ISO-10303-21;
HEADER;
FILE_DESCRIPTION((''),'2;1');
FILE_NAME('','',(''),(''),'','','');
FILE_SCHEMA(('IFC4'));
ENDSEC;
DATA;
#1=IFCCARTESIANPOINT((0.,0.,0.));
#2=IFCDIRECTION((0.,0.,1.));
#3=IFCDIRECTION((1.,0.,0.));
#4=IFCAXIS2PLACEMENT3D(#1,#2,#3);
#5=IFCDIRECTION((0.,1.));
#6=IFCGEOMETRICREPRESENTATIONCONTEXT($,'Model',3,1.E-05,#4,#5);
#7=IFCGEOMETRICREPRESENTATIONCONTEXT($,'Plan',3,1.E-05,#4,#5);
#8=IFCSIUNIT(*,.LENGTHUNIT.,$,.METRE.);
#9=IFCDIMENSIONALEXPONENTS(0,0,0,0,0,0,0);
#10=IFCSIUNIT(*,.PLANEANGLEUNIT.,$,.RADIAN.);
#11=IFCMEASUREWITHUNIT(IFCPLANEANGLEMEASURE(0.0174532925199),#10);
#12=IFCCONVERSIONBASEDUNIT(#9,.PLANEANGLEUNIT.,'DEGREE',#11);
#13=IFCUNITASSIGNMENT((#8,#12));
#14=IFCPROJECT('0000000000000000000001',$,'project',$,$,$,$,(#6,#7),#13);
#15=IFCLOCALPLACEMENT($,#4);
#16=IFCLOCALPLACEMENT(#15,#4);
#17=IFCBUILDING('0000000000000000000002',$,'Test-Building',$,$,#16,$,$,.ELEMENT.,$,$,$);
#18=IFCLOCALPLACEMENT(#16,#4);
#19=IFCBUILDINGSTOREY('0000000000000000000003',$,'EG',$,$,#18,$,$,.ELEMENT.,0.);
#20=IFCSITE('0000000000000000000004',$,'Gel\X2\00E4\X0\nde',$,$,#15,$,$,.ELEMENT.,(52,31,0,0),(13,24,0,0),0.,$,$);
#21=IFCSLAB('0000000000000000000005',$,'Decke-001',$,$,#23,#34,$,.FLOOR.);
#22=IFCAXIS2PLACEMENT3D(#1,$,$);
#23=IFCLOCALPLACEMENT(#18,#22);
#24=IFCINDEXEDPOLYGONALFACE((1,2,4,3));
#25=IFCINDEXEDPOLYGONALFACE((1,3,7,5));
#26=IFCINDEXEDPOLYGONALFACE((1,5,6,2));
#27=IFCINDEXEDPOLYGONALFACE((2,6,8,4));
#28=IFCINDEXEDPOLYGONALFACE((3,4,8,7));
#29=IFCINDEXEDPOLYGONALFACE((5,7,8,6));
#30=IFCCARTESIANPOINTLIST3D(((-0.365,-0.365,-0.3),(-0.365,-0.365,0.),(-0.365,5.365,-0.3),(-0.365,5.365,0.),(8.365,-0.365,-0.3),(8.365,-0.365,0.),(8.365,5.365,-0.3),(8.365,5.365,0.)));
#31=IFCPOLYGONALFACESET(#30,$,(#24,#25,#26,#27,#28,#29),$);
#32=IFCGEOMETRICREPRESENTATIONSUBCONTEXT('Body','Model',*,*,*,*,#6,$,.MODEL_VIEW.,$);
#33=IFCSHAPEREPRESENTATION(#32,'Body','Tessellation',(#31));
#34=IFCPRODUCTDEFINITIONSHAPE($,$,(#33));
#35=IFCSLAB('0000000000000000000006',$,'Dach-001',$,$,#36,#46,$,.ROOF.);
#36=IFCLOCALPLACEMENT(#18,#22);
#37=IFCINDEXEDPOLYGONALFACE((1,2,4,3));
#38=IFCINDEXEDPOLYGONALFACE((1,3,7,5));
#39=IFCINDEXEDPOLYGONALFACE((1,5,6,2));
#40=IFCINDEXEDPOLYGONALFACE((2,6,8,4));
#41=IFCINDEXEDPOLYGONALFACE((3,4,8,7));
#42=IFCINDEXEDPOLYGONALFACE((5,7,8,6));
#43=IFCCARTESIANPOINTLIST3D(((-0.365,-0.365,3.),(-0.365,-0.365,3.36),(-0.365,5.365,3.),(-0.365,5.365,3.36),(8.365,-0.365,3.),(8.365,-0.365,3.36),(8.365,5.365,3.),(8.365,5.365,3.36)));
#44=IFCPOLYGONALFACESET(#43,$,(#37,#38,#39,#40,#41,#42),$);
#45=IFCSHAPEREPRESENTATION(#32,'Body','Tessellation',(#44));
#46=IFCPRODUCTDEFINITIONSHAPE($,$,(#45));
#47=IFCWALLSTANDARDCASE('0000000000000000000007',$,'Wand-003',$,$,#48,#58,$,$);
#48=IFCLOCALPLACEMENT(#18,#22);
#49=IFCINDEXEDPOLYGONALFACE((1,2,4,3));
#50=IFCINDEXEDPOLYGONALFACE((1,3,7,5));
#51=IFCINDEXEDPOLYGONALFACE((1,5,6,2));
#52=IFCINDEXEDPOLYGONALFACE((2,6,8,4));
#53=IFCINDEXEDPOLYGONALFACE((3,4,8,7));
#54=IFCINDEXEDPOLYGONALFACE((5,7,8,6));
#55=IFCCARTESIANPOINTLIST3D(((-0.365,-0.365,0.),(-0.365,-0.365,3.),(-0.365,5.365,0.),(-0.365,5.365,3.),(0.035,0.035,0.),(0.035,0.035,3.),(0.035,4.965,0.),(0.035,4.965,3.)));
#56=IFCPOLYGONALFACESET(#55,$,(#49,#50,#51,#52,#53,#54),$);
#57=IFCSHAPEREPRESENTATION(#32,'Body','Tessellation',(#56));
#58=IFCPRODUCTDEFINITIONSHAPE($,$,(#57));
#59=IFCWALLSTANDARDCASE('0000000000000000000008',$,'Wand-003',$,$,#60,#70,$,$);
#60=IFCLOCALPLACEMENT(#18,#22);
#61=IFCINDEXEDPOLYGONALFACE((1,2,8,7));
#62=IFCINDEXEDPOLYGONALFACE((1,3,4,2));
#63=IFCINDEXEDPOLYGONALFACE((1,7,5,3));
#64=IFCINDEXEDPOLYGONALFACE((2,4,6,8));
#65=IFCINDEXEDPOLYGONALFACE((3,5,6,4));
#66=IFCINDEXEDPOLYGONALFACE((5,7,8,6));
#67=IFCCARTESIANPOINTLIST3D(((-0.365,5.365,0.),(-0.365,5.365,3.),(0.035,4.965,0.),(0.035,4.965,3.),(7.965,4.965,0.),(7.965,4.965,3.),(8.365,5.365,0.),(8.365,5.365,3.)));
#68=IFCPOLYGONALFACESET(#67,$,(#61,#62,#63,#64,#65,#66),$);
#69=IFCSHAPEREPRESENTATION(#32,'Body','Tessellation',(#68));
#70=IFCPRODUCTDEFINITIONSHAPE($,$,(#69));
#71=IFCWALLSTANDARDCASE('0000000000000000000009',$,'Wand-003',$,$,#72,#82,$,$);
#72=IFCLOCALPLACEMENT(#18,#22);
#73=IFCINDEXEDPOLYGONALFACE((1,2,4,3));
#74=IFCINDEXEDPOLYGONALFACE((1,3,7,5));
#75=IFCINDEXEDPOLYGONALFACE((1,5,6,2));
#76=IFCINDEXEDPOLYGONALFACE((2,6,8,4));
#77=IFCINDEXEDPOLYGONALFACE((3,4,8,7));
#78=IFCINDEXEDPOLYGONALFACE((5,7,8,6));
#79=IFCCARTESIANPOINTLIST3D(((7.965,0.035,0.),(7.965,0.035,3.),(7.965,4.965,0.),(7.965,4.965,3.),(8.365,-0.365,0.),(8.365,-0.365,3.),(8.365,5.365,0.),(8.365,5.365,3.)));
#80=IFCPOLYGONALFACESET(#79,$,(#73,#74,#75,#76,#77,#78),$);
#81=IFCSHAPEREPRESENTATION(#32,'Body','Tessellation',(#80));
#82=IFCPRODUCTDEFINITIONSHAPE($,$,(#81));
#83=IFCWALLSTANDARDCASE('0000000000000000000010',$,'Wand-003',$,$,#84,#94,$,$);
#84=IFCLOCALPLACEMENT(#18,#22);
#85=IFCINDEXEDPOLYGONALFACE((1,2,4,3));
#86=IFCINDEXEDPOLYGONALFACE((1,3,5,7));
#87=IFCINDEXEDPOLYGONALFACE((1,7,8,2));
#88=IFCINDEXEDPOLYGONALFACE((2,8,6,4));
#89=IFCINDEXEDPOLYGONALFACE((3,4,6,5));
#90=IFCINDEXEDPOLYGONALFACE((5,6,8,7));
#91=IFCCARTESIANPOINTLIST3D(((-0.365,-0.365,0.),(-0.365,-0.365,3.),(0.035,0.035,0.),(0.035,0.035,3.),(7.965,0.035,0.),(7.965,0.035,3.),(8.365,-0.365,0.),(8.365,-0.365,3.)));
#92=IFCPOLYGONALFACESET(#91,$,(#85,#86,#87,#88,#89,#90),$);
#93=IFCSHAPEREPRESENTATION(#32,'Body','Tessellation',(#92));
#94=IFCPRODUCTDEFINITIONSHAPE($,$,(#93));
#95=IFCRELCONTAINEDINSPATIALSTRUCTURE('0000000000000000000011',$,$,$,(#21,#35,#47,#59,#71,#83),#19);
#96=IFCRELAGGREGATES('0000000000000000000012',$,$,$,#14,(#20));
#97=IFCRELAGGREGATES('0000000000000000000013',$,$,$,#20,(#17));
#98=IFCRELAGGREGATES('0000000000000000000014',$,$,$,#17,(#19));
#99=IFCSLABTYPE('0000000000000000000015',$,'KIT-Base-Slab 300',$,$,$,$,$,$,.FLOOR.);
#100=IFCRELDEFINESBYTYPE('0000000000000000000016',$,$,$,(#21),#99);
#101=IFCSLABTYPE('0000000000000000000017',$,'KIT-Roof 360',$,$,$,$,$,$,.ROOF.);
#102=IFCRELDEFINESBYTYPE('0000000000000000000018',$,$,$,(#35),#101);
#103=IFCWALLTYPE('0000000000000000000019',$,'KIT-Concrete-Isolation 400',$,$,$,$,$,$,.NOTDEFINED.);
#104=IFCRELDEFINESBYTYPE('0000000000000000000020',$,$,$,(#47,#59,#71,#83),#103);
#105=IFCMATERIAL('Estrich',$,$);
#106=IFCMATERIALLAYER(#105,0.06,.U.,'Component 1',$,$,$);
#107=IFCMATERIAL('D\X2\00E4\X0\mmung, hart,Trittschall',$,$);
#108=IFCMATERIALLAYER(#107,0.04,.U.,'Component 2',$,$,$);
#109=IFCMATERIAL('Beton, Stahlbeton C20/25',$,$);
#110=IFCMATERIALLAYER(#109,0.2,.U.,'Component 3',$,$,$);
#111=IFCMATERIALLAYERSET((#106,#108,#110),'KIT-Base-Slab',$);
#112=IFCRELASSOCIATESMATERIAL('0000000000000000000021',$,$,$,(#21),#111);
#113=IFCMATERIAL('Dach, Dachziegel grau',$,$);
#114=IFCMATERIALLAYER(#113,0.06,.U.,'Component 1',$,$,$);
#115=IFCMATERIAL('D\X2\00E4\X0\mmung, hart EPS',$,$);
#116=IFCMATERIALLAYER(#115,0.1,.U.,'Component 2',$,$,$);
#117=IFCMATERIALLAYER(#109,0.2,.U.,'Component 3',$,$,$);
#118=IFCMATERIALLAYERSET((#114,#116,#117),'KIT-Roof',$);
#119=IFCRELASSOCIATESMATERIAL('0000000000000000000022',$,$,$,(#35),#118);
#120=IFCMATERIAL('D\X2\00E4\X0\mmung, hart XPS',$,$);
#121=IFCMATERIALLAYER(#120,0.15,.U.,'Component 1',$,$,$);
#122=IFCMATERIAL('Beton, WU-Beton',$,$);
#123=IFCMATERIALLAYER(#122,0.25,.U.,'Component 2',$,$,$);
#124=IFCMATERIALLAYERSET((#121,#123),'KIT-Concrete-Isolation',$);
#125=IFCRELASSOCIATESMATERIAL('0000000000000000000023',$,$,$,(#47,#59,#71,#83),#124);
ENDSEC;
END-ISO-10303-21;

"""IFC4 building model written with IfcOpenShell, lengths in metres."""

from ifc_helpers import new_model, entity, si_unit, converted_unit, direction, frame, origin_with_axes, place, context, subcontext, project, spatial, polyline, outline, extrude, material, layer, layer_set, layer_usage, type_object, element, save


model = new_model("IFC4")

# Units and contexts
model_context = context("Model", 3, precision=1e-05, world=origin_with_axes(), true_north=direction((0.0, 1.0)))
plan_context = context("Plan", 3, precision=1e-05, world=origin_with_axes(), true_north=direction((0.0, 1.0)))
body_context = subcontext(model_context, "Body", "Model", "MODEL_VIEW")
ifc_project = project(units=[si_unit("LENGTHUNIT", "METRE"), converted_unit("PLANEANGLEUNIT", "DEGREE", entity("IfcPlaneAngleMeasure", 0.0174532925199), si_unit("PLANEANGLEUNIT", "RADIAN"), dimensions=[0, 0, 0, 0, 0, 0, 0])], contexts=[model_context, plan_context])

# Site, building, storey
site_placement = place(None, origin_with_axes())
site = spatial("IfcSite", under=ifc_project, at=site_placement, Name="Gelände", CompositionType="ELEMENT", RefLatitude=(52, 31, 0, 0), RefLongitude=(13, 24, 0, 0), RefElevation=0.0)
building_placement = place(site_placement, origin_with_axes())
building = spatial("IfcBuilding", under=site, at=building_placement, Name="Test-Building", CompositionType="ELEMENT")
storey_placement = place(building_placement, origin_with_axes())
storey = spatial("IfcBuildingStorey", under=building, at=storey_placement, Name="EG", CompositionType="ELEMENT", Elevation=0.0)

# Slabs
ifc_material_1 = material(Name="Estrich")
ifc_layer_1 = layer(ifc_material_1, 0.06, ventilated="UNKNOWN", Name="Component 1")
ifc_material_2 = material(Name="Dämmung, hart,Trittschall")
ifc_layer_2 = layer(ifc_material_2, 0.04, ventilated="UNKNOWN", Name="Component 2")
ifc_material_3 = material(Name="Beton, Stahlbeton C20/25")
ifc_layer_3 = layer(ifc_material_3, 0.2, ventilated="UNKNOWN", Name="Component 3")
ifc_layer_set_1 = layer_set([ifc_layer_1, ifc_layer_2, ifc_layer_3], Name="KIT-Base-Slab")
ifc_layer_usage_1 = layer_usage(ifc_layer_set_1, "AXIS3", "NEGATIVE", 0.3)
slab_type_1 = type_object("IfcSlabType", Name="KIT-Base-Slab 300", PredefinedType="FLOOR")
slab_1_placement = place(storey_placement, frame((-0.365, -0.365, 0.0), z_axis=(0.0, 0.0, 1.0), x_axis=(1.0, 0.0, 0.0)))
element("IfcSlab", 1, at=slab_1_placement, inside=storey, type_object=slab_type_1, material=ifc_layer_usage_1, Name="Decke-001", PredefinedType="FLOOR", context=body_context, shape_type="SweptSolid", body=[
    extrude(outline(polyline([(0.0, 0.0), (8.73, 0.0), (8.73, 5.73), (0.0, 5.73), (0.0, 0.0)])), frame((0.0, 0.0, -0.3), z_axis=(0.0, 0.0, 1.0), x_axis=(1.0, 0.0, 0.0)), (0.0, 0.0, 1.0), 0.3),
])
ifc_material_4 = material(Name="Dach, Dachziegel grau")
ifc_layer_4 = layer(ifc_material_4, 0.06, ventilated="UNKNOWN", Name="Component 1")
ifc_material_5 = material(Name="Dämmung, hart EPS")
ifc_layer_5 = layer(ifc_material_5, 0.1, ventilated="UNKNOWN", Name="Component 2")
ifc_layer_6 = layer(ifc_material_3, 0.2, ventilated="UNKNOWN", Name="Component 3")
ifc_layer_set_2 = layer_set([ifc_layer_4, ifc_layer_5, ifc_layer_6], Name="KIT-Roof")
ifc_layer_usage_2 = layer_usage(ifc_layer_set_2, "AXIS3", "NEGATIVE", 0.36)
slab_type_2 = type_object("IfcSlabType", Name="KIT-Roof 360", PredefinedType="ROOF")
slab_2_placement = place(storey_placement, frame((-0.365, -0.365, 3.0), z_axis=(0.0, 0.0, 1.0), x_axis=(1.0, 0.0, 0.0)))
element("IfcSlab", 2, at=slab_2_placement, inside=storey, type_object=slab_type_2, material=ifc_layer_usage_2, Name="Dach-001", PredefinedType="ROOF", context=body_context, shape_type="SweptSolid", body=[
    extrude(outline(polyline([(0.0, 0.0), (8.73, 0.0), (8.73, 5.73), (0.0, 5.73), (0.0, 0.0)])), origin_with_axes(), (0.0, 0.0, 1.0), 0.36),
])

# Walls
ifc_material_6 = material(Name="Dämmung, hart XPS")
ifc_layer_7 = layer(ifc_material_6, 0.15, ventilated="UNKNOWN", Name="Component 1")
ifc_material_7 = material(Name="Beton, WU-Beton")
ifc_layer_8 = layer(ifc_material_7, 0.25, ventilated="UNKNOWN", Name="Component 2")
ifc_layer_set_3 = layer_set([ifc_layer_7, ifc_layer_8], Name="KIT-Concrete-Isolation")
ifc_layer_usage_3 = layer_usage(ifc_layer_set_3, "AXIS2", "NEGATIVE", 0.0)
wall_type_1 = type_object("IfcWallType", Name="KIT-Concrete-Isolation 400", PredefinedType="NOTDEFINED")
wall_1_placement = place(storey_placement, frame((-0.365, -0.365, 0.0), z_axis=(0.0, 0.0, 1.0), x_axis=(0.0, 1.0, 0.0)))
element("IfcWallStandardCase", 3, at=wall_1_placement, inside=storey, type_object=wall_type_1, material=ifc_layer_usage_3, Name="Wand-003", context=body_context, shape_type="SweptSolid", body=[
    extrude(outline(polyline([(0.4, -0.4), (5.33, -0.4), (5.73, 0.0), (0.0, 0.0), (0.4, -0.4)])), origin_with_axes(), (0.0, 0.0, 1.0), 3.0),
])
ifc_layer_usage_4 = layer_usage(ifc_layer_set_3, "AXIS2", "NEGATIVE", 0.0)
wall_2_placement = place(storey_placement, frame((-0.365, 5.365, 0.0), z_axis=(0.0, 0.0, 1.0), x_axis=(1.0, 0.0, 0.0)))
element("IfcWallStandardCase", 4, at=wall_2_placement, inside=storey, type_object=wall_type_1, material=ifc_layer_usage_4, Name="Wand-003", context=body_context, shape_type="SweptSolid", body=[
    extrude(outline(polyline([(0.4, -0.4), (8.33, -0.4), (8.73, 0.0), (0.0, 0.0), (0.4, -0.4)])), origin_with_axes(), (0.0, 0.0, 1.0), 3.0),
])
ifc_layer_usage_5 = layer_usage(ifc_layer_set_3, "AXIS2", "NEGATIVE", 0.0)
wall_3_placement = place(storey_placement, frame((8.365, 5.365, 0.0), z_axis=(0.0, 0.0, 1.0), x_axis=(0.0, -1.0, 0.0)))
element("IfcWallStandardCase", 5, at=wall_3_placement, inside=storey, type_object=wall_type_1, material=ifc_layer_usage_5, Name="Wand-003", context=body_context, shape_type="SweptSolid", body=[
    extrude(outline(polyline([(0.4, -0.4), (5.33, -0.4), (5.73, 0.0), (0.0, 0.0), (0.4, -0.4)])), origin_with_axes(), (0.0, 0.0, 1.0), 3.0),
])
ifc_layer_usage_6 = layer_usage(ifc_layer_set_3, "AXIS2", "NEGATIVE", 0.0)
wall_4_placement = place(storey_placement, frame((8.365, -0.365, 0.0), z_axis=(0.0, 0.0, 1.0), x_axis=(-1.0, 0.0, 0.0)))
element("IfcWallStandardCase", 6, at=wall_4_placement, inside=storey, type_object=wall_type_1, material=ifc_layer_usage_6, Name="Wand-003", context=body_context, shape_type="SweptSolid", body=[
    extrude(outline(polyline([(0.4, -0.4), (8.33, -0.4), (8.73, 0.0), (0.0, 0.0), (0.4, -0.4)])), origin_with_axes(), (0.0, 0.0, 1.0), 3.0),
])

save(model, "model.ifc")
